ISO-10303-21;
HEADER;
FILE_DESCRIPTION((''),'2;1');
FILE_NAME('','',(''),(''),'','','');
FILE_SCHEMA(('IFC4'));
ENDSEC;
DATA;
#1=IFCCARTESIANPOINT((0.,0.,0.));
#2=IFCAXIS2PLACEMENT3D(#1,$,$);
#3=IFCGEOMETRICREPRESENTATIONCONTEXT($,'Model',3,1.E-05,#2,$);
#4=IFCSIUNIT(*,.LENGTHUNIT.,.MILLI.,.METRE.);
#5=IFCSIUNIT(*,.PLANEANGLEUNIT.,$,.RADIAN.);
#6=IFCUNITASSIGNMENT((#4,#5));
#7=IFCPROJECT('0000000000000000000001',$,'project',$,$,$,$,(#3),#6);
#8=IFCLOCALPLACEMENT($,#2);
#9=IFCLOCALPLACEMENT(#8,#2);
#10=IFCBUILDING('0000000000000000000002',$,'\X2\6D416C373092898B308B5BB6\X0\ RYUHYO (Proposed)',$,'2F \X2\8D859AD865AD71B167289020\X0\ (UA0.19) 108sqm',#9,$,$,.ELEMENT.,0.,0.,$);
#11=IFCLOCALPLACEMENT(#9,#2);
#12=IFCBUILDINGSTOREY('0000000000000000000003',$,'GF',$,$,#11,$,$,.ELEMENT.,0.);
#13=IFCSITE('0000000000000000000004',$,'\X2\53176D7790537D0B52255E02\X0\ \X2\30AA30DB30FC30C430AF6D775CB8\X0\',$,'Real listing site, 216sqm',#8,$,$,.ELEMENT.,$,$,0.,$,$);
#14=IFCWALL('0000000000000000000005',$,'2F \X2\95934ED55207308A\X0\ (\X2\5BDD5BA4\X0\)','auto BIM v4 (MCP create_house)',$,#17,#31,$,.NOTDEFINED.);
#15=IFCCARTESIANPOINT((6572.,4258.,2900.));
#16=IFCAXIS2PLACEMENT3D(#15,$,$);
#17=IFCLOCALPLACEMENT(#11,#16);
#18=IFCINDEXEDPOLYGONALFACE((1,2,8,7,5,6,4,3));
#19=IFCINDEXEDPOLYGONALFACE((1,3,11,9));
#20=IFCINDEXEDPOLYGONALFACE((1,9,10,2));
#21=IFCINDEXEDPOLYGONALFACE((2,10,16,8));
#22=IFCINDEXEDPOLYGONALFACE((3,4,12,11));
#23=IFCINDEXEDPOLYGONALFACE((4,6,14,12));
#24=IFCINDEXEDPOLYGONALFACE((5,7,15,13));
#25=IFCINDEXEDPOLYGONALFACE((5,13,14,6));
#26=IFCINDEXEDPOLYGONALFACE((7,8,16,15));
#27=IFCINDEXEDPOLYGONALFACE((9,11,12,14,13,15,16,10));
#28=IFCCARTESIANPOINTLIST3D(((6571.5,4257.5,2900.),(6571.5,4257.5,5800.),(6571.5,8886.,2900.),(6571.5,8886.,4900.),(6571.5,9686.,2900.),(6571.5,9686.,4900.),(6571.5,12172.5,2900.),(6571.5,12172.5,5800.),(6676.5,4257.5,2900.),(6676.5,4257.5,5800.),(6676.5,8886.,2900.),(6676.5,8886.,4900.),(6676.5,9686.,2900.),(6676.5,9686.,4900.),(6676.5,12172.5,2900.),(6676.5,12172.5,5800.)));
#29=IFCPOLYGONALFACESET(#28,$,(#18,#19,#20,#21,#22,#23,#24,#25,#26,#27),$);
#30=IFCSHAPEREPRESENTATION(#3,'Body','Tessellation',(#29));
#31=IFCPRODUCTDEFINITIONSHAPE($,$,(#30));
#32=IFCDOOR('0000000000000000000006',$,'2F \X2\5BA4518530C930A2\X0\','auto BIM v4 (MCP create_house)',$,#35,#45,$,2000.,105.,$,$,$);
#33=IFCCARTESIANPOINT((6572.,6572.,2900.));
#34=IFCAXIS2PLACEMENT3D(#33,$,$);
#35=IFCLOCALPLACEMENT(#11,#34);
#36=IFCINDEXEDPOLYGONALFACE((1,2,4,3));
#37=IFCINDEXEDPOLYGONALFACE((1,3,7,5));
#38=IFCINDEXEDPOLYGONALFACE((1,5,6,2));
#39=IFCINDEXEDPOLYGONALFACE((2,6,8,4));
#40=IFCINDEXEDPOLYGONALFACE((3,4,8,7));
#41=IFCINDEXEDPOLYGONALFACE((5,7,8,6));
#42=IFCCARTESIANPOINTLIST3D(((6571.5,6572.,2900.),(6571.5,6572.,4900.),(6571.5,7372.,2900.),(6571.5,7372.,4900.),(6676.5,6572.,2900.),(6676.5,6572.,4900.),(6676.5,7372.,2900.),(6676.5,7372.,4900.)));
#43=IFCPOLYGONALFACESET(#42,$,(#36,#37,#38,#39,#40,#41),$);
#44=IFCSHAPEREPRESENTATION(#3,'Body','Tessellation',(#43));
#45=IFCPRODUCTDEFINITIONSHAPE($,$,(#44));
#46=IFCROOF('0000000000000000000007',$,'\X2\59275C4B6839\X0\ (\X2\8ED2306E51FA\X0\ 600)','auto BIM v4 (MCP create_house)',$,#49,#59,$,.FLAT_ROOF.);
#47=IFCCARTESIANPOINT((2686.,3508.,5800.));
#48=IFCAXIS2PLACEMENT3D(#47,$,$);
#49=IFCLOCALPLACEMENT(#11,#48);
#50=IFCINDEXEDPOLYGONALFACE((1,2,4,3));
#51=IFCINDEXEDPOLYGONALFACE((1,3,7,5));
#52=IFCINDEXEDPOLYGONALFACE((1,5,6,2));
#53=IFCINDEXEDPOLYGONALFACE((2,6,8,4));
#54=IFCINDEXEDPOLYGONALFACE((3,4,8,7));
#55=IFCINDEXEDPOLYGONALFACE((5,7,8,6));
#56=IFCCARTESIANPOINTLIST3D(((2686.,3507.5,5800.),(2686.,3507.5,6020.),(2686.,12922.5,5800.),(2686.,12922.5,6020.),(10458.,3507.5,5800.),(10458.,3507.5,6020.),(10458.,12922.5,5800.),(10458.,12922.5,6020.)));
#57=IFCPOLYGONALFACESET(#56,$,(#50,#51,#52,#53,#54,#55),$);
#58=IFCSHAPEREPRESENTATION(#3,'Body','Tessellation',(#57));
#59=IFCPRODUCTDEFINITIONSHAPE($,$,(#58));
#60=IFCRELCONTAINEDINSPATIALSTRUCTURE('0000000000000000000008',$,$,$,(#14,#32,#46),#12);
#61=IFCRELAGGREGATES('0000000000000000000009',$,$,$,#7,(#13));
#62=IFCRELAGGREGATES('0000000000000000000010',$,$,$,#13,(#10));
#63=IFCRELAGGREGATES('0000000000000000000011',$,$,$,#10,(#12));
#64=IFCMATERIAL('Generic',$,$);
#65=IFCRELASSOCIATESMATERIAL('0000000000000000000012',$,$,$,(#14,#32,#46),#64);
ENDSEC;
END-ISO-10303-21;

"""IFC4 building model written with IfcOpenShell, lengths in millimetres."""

from ifc_helpers import new_model, si_unit, frame, frame_2d, origin, place, context, project, spatial, rectangle, extrude, material, element, fill, save


model = new_model("IFC4")

# Units and contexts
model_context = context("Model", 3, precision=1e-05, world=origin())
ifc_project = project(units=[si_unit("LENGTHUNIT", "METRE", prefix="MILLI"), si_unit("PLANEANGLEUNIT", "RADIAN")], contexts=[model_context])

# Site, building, storey
site_placement = place(None, origin())
site = spatial("IfcSite", under=ifc_project, at=site_placement, Name="北海道紋別市 オホーツク海岸", ObjectType="Real listing site, 216sqm", CompositionType="ELEMENT", RefElevation=0.0)
building_placement = place(site_placement, origin())
building = spatial("IfcBuilding", under=site, at=building_placement, Name="流氷を見る家 RYUHYO (Proposed)", ObjectType="2F 超高断熱木造 (UA0.19) 108sqm", CompositionType="ELEMENT", ElevationOfRefHeight=0.0, ElevationOfTerrain=0.0)
storey_placement = place(building_placement, origin())
storey = spatial("IfcBuildingStorey", under=building, at=storey_placement, Name="GF", CompositionType="ELEMENT", Elevation=0.0)

# Shared definitions
ifc_material = material(Name="Generic")

# Wall, opening, door
wall_1_placement = place(storey_placement, frame((6572.0, 4258.0, 2900.0)))
wall_1 = element("IfcWall", 1, at=wall_1_placement, inside=storey, material=ifc_material, Name="2F 間仕切り (寝室)", Description="auto BIM v4 (MCP create_house)", PredefinedType="NOTDEFINED", context=model_context, shape_type="SweptSolid", body=[
    extrude(rectangle(XDim=105.0, YDim=7915.0, at=frame_2d((52.0, 3957.0))), frame((6572.0, 4258.0, 2900.0)), (0.0, 0.0, 1.0), 2900.0),
])
opening_1_placement = place(storey_placement, frame((6572.0, 6572.0, 2900.0)))
opening_1 = element("IfcOpeningElement", 2, at=opening_1_placement, cuts=wall_1, PredefinedType="NOTDEFINED", context=model_context, shape_type="SweptSolid", body=[
    extrude(rectangle(XDim=105.0, YDim=800.0, at=frame_2d((52.0, 400.0))), frame((6572.0, 6572.0, 2900.0)), (0.0, 0.0, 1.0), 2000.0),
])
door_1_placement = place(storey_placement, frame((6572.0, 6572.0, 2900.0)))
door_1 = element("IfcDoor", 3, at=door_1_placement, inside=storey, material=ifc_material, Name="2F 室内ドア", Description="auto BIM v4 (MCP create_house)", OverallHeight=2000.0, OverallWidth=105.0, context=model_context, shape_type="SweptSolid", body=[
    extrude(rectangle(XDim=105.0, YDim=800.0, at=frame_2d((52.0, 400.0))), frame((6572.0, 6572.0, 2900.0)), (0.0, 0.0, 1.0), 2000.0),
])
fill(opening_1, door_1)

# Roof
roof_placement = place(storey_placement, frame((2686.0, 3508.0, 5800.0)))
element("IfcRoof", 4, at=roof_placement, inside=storey, material=ifc_material, Name="大屋根 (軒の出 600)", Description="auto BIM v4 (MCP create_house)", PredefinedType="FLAT_ROOF", context=model_context, shape_type="SweptSolid", body=[
    extrude(rectangle(XDim=7772.0, YDim=9415.0, at=frame_2d((3886.0, 4707.0))), frame((2686.0, 3508.0, 5800.0)), (0.0, 0.0, 1.0), 220.0),
])

save(model, "model.ifc")
